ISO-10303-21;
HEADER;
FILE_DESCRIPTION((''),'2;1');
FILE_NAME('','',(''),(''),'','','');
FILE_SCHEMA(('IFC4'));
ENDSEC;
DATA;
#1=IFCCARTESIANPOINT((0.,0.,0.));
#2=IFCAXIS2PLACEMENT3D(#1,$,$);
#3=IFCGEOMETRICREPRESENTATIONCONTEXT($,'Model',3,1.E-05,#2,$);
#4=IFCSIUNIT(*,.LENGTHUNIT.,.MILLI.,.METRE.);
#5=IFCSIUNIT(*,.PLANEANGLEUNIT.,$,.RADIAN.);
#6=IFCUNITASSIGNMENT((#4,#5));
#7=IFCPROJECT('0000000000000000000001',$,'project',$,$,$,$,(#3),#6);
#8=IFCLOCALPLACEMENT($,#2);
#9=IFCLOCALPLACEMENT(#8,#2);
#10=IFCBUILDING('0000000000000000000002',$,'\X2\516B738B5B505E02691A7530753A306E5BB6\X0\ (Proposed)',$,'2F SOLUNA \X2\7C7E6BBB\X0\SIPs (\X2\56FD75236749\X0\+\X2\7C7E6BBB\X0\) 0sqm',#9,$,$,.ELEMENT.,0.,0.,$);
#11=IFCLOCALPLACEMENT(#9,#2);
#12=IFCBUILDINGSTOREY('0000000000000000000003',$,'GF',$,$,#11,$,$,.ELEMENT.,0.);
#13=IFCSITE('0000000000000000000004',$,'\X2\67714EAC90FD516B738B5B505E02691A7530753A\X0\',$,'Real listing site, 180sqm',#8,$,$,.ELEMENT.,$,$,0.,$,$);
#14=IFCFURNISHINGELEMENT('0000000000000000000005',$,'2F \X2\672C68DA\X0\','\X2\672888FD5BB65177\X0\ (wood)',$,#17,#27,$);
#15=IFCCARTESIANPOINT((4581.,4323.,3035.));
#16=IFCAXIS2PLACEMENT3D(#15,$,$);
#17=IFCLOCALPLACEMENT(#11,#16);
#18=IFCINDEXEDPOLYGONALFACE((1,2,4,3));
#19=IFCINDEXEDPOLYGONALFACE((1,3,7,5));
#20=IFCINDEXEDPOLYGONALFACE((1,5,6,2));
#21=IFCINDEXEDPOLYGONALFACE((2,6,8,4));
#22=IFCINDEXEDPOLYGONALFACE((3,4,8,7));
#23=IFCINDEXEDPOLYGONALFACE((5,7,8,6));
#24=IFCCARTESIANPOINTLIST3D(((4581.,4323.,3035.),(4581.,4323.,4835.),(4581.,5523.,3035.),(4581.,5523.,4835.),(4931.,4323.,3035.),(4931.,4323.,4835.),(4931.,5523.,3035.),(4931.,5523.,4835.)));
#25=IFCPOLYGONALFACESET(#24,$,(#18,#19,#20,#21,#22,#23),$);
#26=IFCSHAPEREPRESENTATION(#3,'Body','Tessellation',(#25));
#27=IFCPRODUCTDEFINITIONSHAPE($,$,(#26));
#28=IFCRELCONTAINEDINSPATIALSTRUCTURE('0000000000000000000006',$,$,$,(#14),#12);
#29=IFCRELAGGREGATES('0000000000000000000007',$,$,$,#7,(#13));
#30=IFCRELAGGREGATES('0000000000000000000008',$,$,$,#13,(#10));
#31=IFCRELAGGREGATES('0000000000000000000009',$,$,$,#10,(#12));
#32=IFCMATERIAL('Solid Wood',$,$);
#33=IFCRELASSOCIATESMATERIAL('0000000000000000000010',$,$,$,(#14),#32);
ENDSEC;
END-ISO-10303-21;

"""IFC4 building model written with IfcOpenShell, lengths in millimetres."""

from ifc_helpers import new_model, si_unit, frame, frame_2d, origin, place, context, project, spatial, rectangle, extrude, material, element, save


model = new_model("IFC4")

# Units and contexts
model_context = context("Model", 3, precision=1e-05, world=origin())
ifc_project = project(units=[si_unit("LENGTHUNIT", "METRE", prefix="MILLI"), si_unit("PLANEANGLEUNIT", "RADIAN")], contexts=[model_context])

# Site, building, storey
site_placement = place(None, origin())
site = spatial("IfcSite", under=ifc_project, at=site_placement, Name="東京都八王子市椚田町", ObjectType="Real listing site, 180sqm", CompositionType="ELEMENT", RefElevation=0.0)
building_placement = place(site_placement, origin())
building = spatial("IfcBuilding", under=site, at=building_placement, Name="八王子市椚田町の家 (Proposed)", ObjectType="2F SOLUNA 籾殻SIPs (国産杉+籾殻) 0sqm", CompositionType="ELEMENT", ElevationOfRefHeight=0.0, ElevationOfTerrain=0.0)
storey_placement = place(building_placement, origin())
storey = spatial("IfcBuildingStorey", under=building, at=storey_placement, Name="GF", CompositionType="ELEMENT", Elevation=0.0)

# Shared definitions
ifc_material_1 = material(Name="Solid Wood")

# Furnishing element
furnishing_1_placement = place(storey_placement, frame((4581.0, 4323.0, 3035.0)))
element("IfcFurnishingElement", 1, at=furnishing_1_placement, inside=storey, material=ifc_material_1, Name="2F 本棚", Description="木製家具 (wood)", context=model_context, shape_type="SweptSolid", body=[
    extrude(rectangle(XDim=350.0, YDim=1200.0, at=frame_2d((175.0, 600.0))), frame((4581.0, 4323.0, 3035.0)), (0.0, 0.0, 1.0), 1800.0),
])

save(model, "model.ifc")
